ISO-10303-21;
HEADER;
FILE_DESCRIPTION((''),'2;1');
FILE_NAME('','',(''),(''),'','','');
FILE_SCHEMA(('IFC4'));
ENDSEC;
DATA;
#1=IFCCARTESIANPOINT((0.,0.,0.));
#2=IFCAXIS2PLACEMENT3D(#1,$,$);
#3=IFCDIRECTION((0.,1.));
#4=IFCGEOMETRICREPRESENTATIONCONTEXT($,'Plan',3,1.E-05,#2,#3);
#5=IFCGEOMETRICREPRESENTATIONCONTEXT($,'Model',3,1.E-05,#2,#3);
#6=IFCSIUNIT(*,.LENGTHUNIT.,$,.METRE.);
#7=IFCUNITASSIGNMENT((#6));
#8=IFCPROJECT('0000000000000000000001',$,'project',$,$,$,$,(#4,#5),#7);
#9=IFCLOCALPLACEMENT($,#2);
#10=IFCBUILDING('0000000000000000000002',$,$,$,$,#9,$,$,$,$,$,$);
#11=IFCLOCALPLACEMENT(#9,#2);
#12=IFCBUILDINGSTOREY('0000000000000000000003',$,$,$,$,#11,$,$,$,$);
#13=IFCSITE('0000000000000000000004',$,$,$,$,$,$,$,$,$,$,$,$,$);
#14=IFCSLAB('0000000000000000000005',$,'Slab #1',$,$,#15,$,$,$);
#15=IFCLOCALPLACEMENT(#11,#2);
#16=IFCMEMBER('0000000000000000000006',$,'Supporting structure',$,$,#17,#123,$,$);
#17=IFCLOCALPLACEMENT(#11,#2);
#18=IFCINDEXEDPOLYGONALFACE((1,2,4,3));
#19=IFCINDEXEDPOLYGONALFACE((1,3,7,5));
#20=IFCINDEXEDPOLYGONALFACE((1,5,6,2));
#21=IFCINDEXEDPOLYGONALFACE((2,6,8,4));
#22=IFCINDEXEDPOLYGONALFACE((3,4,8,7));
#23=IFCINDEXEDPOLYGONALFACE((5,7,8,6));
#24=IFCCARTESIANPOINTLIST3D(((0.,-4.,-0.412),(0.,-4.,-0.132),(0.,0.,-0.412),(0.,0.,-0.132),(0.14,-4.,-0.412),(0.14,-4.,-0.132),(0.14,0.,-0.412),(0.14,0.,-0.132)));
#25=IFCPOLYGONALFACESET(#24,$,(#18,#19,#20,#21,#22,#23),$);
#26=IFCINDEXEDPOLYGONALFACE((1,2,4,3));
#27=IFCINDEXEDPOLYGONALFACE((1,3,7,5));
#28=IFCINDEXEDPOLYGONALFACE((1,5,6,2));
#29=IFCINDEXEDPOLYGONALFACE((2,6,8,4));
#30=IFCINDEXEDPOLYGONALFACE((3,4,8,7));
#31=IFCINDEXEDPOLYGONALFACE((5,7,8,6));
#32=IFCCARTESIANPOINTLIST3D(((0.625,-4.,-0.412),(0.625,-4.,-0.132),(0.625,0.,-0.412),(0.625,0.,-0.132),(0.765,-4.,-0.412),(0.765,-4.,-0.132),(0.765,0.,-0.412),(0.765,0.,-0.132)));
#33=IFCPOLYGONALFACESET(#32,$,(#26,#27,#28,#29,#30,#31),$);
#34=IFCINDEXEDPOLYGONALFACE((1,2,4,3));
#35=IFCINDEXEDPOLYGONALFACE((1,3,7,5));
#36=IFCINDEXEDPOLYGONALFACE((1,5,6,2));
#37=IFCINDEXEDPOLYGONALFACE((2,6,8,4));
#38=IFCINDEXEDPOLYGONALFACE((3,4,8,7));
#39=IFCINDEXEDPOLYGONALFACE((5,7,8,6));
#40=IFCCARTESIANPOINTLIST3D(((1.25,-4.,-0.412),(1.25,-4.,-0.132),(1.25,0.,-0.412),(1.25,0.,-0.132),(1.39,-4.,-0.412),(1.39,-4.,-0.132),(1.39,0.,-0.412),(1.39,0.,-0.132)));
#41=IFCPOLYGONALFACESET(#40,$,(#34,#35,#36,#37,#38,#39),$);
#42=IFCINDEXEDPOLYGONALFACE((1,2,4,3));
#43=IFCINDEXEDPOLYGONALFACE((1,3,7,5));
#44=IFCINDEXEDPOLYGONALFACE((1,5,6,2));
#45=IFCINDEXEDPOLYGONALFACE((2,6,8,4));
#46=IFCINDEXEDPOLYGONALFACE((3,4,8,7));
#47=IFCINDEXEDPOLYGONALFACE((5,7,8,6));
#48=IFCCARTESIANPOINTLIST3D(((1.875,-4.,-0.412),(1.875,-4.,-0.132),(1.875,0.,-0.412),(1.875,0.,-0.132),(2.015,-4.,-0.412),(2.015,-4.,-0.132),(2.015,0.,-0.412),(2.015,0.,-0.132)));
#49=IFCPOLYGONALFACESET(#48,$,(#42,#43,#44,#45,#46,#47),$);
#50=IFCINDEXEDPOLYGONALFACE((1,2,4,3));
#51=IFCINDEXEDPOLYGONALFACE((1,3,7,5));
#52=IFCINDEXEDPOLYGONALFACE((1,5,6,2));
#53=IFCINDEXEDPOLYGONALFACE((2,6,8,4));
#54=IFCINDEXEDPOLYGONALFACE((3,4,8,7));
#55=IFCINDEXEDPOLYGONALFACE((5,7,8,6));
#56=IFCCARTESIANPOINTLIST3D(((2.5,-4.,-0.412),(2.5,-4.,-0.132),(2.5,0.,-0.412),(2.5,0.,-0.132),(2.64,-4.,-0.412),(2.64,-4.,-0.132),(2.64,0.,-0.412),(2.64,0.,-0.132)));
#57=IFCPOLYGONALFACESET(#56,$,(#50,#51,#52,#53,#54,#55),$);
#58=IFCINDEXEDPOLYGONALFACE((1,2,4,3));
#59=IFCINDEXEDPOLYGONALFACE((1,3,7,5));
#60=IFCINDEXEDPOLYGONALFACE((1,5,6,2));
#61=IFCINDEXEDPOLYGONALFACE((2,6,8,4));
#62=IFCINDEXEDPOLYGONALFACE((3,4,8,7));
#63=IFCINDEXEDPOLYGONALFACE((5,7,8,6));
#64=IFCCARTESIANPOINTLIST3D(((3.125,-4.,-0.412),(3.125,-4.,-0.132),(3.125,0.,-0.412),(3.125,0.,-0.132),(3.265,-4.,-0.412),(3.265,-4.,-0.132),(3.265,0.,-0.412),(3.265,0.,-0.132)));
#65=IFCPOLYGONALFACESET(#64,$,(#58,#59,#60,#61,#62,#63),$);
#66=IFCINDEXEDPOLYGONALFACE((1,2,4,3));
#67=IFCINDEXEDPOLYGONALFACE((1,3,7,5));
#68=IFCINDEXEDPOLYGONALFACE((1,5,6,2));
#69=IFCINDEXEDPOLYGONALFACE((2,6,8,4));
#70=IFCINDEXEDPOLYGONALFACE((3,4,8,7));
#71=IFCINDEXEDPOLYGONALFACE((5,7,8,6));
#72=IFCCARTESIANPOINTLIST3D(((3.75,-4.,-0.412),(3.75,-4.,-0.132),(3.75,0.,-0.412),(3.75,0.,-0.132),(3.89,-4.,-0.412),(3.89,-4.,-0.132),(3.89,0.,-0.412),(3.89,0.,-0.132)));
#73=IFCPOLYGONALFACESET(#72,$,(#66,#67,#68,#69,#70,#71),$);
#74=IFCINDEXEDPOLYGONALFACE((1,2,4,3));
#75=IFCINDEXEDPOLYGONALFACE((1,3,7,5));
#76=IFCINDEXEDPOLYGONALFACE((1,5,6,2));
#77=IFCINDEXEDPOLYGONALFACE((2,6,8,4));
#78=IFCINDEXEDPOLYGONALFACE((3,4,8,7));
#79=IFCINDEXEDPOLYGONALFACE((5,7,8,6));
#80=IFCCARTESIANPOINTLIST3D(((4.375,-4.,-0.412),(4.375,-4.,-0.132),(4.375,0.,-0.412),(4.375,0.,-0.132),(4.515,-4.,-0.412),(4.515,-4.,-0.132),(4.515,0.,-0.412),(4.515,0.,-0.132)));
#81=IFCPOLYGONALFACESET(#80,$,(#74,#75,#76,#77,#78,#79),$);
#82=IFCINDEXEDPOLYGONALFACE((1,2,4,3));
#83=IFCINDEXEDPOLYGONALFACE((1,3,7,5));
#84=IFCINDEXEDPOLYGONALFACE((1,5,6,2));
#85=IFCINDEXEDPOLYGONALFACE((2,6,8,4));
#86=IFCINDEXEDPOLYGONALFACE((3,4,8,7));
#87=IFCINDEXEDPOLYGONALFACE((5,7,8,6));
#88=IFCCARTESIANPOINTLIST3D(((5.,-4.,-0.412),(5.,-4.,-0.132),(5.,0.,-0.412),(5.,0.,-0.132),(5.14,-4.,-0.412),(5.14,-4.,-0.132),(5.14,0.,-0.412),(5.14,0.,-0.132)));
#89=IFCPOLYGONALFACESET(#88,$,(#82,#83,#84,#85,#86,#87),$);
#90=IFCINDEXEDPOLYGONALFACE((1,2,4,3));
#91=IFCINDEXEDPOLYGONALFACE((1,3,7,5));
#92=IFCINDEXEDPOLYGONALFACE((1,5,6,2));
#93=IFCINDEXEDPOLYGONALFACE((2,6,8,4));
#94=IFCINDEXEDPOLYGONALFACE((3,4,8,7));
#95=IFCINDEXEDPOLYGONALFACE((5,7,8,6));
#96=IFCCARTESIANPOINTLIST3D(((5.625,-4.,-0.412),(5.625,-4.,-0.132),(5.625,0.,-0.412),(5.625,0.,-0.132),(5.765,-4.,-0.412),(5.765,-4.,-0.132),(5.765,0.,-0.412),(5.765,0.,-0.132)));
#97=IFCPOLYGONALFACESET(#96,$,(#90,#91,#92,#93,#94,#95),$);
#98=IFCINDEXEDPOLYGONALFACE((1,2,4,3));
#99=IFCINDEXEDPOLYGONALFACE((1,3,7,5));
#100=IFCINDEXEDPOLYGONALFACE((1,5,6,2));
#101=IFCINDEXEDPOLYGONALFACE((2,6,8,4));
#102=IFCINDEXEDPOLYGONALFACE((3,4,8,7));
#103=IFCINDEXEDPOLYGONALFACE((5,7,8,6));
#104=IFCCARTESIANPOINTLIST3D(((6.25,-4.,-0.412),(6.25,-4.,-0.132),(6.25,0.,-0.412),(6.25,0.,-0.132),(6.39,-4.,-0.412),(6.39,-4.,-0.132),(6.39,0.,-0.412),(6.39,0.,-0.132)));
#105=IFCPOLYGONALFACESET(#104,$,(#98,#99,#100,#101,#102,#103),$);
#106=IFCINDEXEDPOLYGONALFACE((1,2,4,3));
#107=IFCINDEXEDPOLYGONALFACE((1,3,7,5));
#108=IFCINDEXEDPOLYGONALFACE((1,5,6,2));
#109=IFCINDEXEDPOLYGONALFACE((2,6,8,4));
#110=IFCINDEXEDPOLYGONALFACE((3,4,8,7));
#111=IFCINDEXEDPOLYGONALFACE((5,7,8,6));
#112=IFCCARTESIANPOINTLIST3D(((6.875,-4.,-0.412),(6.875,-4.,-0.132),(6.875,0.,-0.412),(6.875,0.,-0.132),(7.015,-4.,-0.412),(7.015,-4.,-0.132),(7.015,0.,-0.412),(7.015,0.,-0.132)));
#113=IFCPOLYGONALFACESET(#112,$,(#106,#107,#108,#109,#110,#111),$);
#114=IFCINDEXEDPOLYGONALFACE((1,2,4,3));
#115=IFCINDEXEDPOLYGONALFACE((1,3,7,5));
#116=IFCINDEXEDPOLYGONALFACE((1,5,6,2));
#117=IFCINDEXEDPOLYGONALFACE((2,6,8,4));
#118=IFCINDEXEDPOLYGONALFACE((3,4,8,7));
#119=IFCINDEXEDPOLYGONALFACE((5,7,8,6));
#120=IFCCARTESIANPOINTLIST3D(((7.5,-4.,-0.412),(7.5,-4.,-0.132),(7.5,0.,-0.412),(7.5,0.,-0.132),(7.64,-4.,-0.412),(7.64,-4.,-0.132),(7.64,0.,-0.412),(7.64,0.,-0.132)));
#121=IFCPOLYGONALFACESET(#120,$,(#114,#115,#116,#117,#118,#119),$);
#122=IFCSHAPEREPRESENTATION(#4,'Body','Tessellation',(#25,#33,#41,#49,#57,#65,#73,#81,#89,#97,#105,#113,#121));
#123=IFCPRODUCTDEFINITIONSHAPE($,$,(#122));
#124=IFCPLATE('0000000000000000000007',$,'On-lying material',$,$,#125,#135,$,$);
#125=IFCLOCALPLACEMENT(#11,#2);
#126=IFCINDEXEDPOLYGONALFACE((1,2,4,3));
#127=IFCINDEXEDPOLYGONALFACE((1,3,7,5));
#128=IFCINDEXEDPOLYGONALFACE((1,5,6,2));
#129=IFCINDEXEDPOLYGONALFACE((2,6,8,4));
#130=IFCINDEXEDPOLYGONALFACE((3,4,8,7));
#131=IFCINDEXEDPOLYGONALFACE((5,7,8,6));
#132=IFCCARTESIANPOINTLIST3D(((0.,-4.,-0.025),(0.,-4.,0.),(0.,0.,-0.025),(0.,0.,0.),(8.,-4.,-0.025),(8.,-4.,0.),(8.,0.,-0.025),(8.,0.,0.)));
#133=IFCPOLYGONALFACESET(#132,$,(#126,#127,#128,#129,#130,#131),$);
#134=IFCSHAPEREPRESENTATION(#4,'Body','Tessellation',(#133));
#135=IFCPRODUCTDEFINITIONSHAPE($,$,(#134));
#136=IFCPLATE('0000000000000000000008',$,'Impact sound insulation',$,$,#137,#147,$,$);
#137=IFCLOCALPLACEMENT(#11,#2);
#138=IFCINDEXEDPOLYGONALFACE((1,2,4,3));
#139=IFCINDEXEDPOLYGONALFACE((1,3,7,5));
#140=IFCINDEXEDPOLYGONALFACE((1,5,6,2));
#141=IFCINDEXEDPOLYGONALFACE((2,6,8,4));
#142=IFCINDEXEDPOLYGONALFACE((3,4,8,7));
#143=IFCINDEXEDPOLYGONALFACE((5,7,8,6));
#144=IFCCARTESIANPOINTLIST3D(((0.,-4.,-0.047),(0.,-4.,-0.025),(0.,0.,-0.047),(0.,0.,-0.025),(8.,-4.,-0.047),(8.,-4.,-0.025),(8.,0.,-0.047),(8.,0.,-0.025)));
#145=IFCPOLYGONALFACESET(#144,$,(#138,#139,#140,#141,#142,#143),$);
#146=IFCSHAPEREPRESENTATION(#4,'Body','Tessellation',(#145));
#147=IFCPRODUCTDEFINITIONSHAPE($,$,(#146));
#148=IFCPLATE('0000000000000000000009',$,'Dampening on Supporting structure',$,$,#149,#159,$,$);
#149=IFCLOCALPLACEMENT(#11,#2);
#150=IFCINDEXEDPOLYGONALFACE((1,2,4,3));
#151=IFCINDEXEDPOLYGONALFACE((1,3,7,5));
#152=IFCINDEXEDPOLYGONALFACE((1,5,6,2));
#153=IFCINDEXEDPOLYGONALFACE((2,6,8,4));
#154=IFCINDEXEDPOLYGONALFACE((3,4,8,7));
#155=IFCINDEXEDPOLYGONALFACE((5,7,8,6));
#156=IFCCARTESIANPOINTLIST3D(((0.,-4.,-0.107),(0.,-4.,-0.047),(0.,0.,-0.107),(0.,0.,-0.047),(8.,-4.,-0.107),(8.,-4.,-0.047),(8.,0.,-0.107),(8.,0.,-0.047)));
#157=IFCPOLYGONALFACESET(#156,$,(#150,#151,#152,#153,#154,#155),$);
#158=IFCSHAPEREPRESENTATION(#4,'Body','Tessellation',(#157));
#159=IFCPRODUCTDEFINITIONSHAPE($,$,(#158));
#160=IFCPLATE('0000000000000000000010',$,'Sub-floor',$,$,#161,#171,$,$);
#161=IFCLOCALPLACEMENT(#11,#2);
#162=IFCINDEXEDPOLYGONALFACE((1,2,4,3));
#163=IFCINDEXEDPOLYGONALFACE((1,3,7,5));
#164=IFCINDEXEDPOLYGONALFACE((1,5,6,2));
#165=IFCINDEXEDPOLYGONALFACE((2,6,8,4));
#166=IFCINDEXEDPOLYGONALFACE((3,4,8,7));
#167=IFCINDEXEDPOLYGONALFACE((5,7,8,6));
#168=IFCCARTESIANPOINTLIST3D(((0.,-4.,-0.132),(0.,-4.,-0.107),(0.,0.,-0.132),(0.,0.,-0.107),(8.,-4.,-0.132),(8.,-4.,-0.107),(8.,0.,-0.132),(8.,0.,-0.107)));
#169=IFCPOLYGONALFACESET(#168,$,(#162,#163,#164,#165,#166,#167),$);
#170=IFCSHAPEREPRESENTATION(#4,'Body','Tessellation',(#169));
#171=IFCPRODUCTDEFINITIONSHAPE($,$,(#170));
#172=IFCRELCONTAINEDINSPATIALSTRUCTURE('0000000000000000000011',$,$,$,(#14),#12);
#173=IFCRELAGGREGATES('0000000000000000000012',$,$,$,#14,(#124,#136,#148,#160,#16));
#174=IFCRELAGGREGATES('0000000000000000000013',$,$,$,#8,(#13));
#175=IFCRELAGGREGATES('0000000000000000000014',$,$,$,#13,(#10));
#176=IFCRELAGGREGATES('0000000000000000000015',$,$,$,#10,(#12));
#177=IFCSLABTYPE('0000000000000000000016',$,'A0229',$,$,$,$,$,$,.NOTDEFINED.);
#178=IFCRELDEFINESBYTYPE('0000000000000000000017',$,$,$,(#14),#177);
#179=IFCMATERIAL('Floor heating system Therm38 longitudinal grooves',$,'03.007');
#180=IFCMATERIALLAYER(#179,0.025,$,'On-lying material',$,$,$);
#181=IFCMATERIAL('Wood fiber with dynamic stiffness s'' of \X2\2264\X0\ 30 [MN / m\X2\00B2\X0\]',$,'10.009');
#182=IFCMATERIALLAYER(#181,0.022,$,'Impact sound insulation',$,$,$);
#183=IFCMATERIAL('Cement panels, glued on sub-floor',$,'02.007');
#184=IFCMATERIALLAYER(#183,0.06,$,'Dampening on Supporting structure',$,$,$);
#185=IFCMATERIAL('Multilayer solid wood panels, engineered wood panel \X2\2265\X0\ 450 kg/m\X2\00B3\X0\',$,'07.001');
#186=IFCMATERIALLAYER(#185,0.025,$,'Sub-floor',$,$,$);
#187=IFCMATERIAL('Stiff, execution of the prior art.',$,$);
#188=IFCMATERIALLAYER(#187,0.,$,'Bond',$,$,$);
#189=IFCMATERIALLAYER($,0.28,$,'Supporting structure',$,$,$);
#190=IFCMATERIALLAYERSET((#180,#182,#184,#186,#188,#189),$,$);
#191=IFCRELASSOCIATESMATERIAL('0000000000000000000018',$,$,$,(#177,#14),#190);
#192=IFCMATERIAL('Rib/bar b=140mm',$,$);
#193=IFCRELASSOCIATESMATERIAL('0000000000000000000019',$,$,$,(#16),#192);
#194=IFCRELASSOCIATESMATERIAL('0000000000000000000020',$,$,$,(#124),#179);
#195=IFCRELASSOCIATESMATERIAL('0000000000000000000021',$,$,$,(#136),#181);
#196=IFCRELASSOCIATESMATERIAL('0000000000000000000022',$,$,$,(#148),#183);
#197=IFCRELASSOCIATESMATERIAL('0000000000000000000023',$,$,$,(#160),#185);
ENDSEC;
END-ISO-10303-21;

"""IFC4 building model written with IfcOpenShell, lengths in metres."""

from ifc_helpers import new_model, si_unit, direction, frame, frame_2d, origin, origin_with_axes, place, context, project, spatial, rectangle, extrude, material, layer, layer_set, type_object, element, aggregate, save


model = new_model("IFC4")

# Units and contexts
plan_context = context("Plan", 3, precision=1e-05, world=origin(), true_north=direction((0.0, 1.0)))
model_context = context("Model", 3, precision=1e-05, world=origin(), true_north=direction((0.0, 1.0)))
ifc_project = project(units=[si_unit("LENGTHUNIT", "METRE")], contexts=[plan_context, model_context])

# Site, building, storey
site = spatial("IfcSite", under=ifc_project)
building_placement = place(None, origin())
building = spatial("IfcBuilding", under=site, at=building_placement)
storey_placement = place(building_placement, origin())
storey = spatial("IfcBuildingStorey", under=building, at=storey_placement)

# Slab, member, plates
ifc_material_1 = material(Name="Floor heating system Therm38 longitudinal grooves", Category="03.007")
ifc_layer_1 = layer(ifc_material_1, 0.025, Name="On-lying material")
ifc_material_2 = material(Name="Wood fiber with dynamic stiffness s' of ≤ 30 [MN / m²]", Category="10.009")
ifc_layer_2 = layer(ifc_material_2, 0.022, Name="Impact sound insulation")
ifc_material_3 = material(Name="Cement panels, glued on sub-floor", Category="02.007")
ifc_layer_3 = layer(ifc_material_3, 0.06, Name="Dampening on Supporting structure")
ifc_material_4 = material(Name="Multilayer solid wood panels, engineered wood panel ≥ 450 kg/m³", Category="07.001")
ifc_layer_4 = layer(ifc_material_4, 0.025, Name="Sub-floor")
ifc_material_5 = material(Name="Stiff, execution of the prior art.")
ifc_layer_5 = layer(ifc_material_5, 0.0, Name="Bond")
ifc_layer_6 = layer(None, 0.28, Name="Supporting structure")
ifc_layer_set = layer_set([ifc_layer_1, ifc_layer_2, ifc_layer_3, ifc_layer_4, ifc_layer_5, ifc_layer_6])
slab_type = type_object("IfcSlabType", Name="A0229", PredefinedType="NOTDEFINED", material=ifc_layer_set)
slab_placement = place(None, frame((0.0, 0.0, 0.0), z_axis=(0.0, 0.0, -1.0), x_axis=(1.0, 0.0, 0.0)))
slab = element("IfcSlab", 1, at=slab_placement, inside=storey, type_object=slab_type, material=ifc_layer_set, Name="Slab #1")
ifc_material_6 = material(Name="Rib/bar b=140mm")
member_placement = place(slab_placement, origin())
member = element("IfcMember", 2, at=member_placement, material=ifc_material_6, Name="Supporting structure", context=plan_context, shape_type="SweptSolid", body=[
    extrude(rectangle(XDim=0.14, YDim=0.28, at=frame_2d((0.07, 0.14), x_axis=(1.0, 0.0))), frame((0.0, 4.0, 0.132), z_axis=(0.0, -1.0, 0.0), x_axis=(1.0, 0.0, 0.0)), (0.0, 0.0, 1.0), 4.0),
    extrude(rectangle(XDim=0.14, YDim=0.28, at=frame_2d((0.07, 0.14), x_axis=(1.0, 0.0))), frame((0.625, 4.0, 0.132), z_axis=(0.0, -1.0, 0.0), x_axis=(1.0, 0.0, 0.0)), (0.0, 0.0, 1.0), 4.0),
    extrude(rectangle(XDim=0.14, YDim=0.28, at=frame_2d((0.07, 0.14), x_axis=(1.0, 0.0))), frame((1.25, 4.0, 0.132), z_axis=(0.0, -1.0, 0.0), x_axis=(1.0, 0.0, 0.0)), (0.0, 0.0, 1.0), 4.0),
    extrude(rectangle(XDim=0.14, YDim=0.28, at=frame_2d((0.07, 0.14), x_axis=(1.0, 0.0))), frame((1.875, 4.0, 0.132), z_axis=(0.0, -1.0, 0.0), x_axis=(1.0, 0.0, 0.0)), (0.0, 0.0, 1.0), 4.0),
    extrude(rectangle(XDim=0.14, YDim=0.28, at=frame_2d((0.07, 0.14), x_axis=(1.0, 0.0))), frame((2.5, 4.0, 0.132), z_axis=(0.0, -1.0, 0.0), x_axis=(1.0, 0.0, 0.0)), (0.0, 0.0, 1.0), 4.0),
    extrude(rectangle(XDim=0.14, YDim=0.28, at=frame_2d((0.07, 0.14), x_axis=(1.0, 0.0))), frame((3.125, 4.0, 0.132), z_axis=(0.0, -1.0, 0.0), x_axis=(1.0, 0.0, 0.0)), (0.0, 0.0, 1.0), 4.0),
    extrude(rectangle(XDim=0.14, YDim=0.28, at=frame_2d((0.07, 0.14), x_axis=(1.0, 0.0))), frame((3.75, 4.0, 0.132), z_axis=(0.0, -1.0, 0.0), x_axis=(1.0, 0.0, 0.0)), (0.0, 0.0, 1.0), 4.0),
    extrude(rectangle(XDim=0.14, YDim=0.28, at=frame_2d((0.07, 0.14), x_axis=(1.0, 0.0))), frame((4.375, 4.0, 0.132), z_axis=(0.0, -1.0, 0.0), x_axis=(1.0, 0.0, 0.0)), (0.0, 0.0, 1.0), 4.0),
    extrude(rectangle(XDim=0.14, YDim=0.28, at=frame_2d((0.07, 0.14), x_axis=(1.0, 0.0))), frame((5.0, 4.0, 0.132), z_axis=(0.0, -1.0, 0.0), x_axis=(1.0, 0.0, 0.0)), (0.0, 0.0, 1.0), 4.0),
    extrude(rectangle(XDim=0.14, YDim=0.28, at=frame_2d((0.07, 0.14), x_axis=(1.0, 0.0))), frame((5.625, 4.0, 0.132), z_axis=(0.0, -1.0, 0.0), x_axis=(1.0, 0.0, 0.0)), (0.0, 0.0, 1.0), 4.0),
    extrude(rectangle(XDim=0.14, YDim=0.28, at=frame_2d((0.07, 0.14), x_axis=(1.0, 0.0))), frame((6.25, 4.0, 0.132), z_axis=(0.0, -1.0, 0.0), x_axis=(1.0, 0.0, 0.0)), (0.0, 0.0, 1.0), 4.0),
    extrude(rectangle(XDim=0.14, YDim=0.28, at=frame_2d((0.07, 0.14), x_axis=(1.0, 0.0))), frame((6.875, 4.0, 0.132), z_axis=(0.0, -1.0, 0.0), x_axis=(1.0, 0.0, 0.0)), (0.0, 0.0, 1.0), 4.0),
    extrude(rectangle(XDim=0.14, YDim=0.28, at=frame_2d((0.07, 0.14), x_axis=(1.0, 0.0))), frame((7.5, 4.0, 0.132), z_axis=(0.0, -1.0, 0.0), x_axis=(1.0, 0.0, 0.0)), (0.0, 0.0, 1.0), 4.0),
])
plate_1_placement = place(slab_placement, origin())
plate_1 = element("IfcPlate", 3, at=plate_1_placement, material=ifc_material_1, Name="On-lying material", context=plan_context, shape_type="SweptSolid", body=[
    extrude(rectangle(XDim=8.0, YDim=4.0, at=frame_2d((4.0, 2.0), x_axis=(1.0, 0.0))), origin_with_axes(), (0.0, 0.0, 1.0), 0.025),
])
plate_2_placement = place(slab_placement, origin())
plate_2 = element("IfcPlate", 4, at=plate_2_placement, material=ifc_material_2, Name="Impact sound insulation", context=plan_context, shape_type="SweptSolid", body=[
    extrude(rectangle(XDim=8.0, YDim=4.0, at=frame_2d((4.0, 2.0), x_axis=(1.0, 0.0))), frame((0.0, 0.0, 0.025), z_axis=(0.0, 0.0, 1.0), x_axis=(1.0, 0.0, 0.0)), (0.0, 0.0, 1.0), 0.022),
])
plate_3_placement = place(slab_placement, origin())
plate_3 = element("IfcPlate", 5, at=plate_3_placement, material=ifc_material_3, Name="Dampening on Supporting structure", context=plan_context, shape_type="SweptSolid", body=[
    extrude(rectangle(XDim=8.0, YDim=4.0, at=frame_2d((4.0, 2.0), x_axis=(1.0, 0.0))), frame((0.0, 0.0, 0.047), z_axis=(0.0, 0.0, 1.0), x_axis=(1.0, 0.0, 0.0)), (0.0, 0.0, 1.0), 0.06),
])
plate_4_placement = place(slab_placement, origin())
plate_4 = element("IfcPlate", 6, at=plate_4_placement, material=ifc_material_4, Name="Sub-floor", context=plan_context, shape_type="SweptSolid", body=[
    extrude(rectangle(XDim=8.0, YDim=4.0, at=frame_2d((4.0, 2.0), x_axis=(1.0, 0.0))), frame((0.0, 0.0, 0.107), z_axis=(0.0, 0.0, 1.0), x_axis=(1.0, 0.0, 0.0)), (0.0, 0.0, 1.0), 0.025),
])
aggregate(slab, [plate_1, plate_2, plate_3, plate_4, member])

save(model, "model.ifc")
